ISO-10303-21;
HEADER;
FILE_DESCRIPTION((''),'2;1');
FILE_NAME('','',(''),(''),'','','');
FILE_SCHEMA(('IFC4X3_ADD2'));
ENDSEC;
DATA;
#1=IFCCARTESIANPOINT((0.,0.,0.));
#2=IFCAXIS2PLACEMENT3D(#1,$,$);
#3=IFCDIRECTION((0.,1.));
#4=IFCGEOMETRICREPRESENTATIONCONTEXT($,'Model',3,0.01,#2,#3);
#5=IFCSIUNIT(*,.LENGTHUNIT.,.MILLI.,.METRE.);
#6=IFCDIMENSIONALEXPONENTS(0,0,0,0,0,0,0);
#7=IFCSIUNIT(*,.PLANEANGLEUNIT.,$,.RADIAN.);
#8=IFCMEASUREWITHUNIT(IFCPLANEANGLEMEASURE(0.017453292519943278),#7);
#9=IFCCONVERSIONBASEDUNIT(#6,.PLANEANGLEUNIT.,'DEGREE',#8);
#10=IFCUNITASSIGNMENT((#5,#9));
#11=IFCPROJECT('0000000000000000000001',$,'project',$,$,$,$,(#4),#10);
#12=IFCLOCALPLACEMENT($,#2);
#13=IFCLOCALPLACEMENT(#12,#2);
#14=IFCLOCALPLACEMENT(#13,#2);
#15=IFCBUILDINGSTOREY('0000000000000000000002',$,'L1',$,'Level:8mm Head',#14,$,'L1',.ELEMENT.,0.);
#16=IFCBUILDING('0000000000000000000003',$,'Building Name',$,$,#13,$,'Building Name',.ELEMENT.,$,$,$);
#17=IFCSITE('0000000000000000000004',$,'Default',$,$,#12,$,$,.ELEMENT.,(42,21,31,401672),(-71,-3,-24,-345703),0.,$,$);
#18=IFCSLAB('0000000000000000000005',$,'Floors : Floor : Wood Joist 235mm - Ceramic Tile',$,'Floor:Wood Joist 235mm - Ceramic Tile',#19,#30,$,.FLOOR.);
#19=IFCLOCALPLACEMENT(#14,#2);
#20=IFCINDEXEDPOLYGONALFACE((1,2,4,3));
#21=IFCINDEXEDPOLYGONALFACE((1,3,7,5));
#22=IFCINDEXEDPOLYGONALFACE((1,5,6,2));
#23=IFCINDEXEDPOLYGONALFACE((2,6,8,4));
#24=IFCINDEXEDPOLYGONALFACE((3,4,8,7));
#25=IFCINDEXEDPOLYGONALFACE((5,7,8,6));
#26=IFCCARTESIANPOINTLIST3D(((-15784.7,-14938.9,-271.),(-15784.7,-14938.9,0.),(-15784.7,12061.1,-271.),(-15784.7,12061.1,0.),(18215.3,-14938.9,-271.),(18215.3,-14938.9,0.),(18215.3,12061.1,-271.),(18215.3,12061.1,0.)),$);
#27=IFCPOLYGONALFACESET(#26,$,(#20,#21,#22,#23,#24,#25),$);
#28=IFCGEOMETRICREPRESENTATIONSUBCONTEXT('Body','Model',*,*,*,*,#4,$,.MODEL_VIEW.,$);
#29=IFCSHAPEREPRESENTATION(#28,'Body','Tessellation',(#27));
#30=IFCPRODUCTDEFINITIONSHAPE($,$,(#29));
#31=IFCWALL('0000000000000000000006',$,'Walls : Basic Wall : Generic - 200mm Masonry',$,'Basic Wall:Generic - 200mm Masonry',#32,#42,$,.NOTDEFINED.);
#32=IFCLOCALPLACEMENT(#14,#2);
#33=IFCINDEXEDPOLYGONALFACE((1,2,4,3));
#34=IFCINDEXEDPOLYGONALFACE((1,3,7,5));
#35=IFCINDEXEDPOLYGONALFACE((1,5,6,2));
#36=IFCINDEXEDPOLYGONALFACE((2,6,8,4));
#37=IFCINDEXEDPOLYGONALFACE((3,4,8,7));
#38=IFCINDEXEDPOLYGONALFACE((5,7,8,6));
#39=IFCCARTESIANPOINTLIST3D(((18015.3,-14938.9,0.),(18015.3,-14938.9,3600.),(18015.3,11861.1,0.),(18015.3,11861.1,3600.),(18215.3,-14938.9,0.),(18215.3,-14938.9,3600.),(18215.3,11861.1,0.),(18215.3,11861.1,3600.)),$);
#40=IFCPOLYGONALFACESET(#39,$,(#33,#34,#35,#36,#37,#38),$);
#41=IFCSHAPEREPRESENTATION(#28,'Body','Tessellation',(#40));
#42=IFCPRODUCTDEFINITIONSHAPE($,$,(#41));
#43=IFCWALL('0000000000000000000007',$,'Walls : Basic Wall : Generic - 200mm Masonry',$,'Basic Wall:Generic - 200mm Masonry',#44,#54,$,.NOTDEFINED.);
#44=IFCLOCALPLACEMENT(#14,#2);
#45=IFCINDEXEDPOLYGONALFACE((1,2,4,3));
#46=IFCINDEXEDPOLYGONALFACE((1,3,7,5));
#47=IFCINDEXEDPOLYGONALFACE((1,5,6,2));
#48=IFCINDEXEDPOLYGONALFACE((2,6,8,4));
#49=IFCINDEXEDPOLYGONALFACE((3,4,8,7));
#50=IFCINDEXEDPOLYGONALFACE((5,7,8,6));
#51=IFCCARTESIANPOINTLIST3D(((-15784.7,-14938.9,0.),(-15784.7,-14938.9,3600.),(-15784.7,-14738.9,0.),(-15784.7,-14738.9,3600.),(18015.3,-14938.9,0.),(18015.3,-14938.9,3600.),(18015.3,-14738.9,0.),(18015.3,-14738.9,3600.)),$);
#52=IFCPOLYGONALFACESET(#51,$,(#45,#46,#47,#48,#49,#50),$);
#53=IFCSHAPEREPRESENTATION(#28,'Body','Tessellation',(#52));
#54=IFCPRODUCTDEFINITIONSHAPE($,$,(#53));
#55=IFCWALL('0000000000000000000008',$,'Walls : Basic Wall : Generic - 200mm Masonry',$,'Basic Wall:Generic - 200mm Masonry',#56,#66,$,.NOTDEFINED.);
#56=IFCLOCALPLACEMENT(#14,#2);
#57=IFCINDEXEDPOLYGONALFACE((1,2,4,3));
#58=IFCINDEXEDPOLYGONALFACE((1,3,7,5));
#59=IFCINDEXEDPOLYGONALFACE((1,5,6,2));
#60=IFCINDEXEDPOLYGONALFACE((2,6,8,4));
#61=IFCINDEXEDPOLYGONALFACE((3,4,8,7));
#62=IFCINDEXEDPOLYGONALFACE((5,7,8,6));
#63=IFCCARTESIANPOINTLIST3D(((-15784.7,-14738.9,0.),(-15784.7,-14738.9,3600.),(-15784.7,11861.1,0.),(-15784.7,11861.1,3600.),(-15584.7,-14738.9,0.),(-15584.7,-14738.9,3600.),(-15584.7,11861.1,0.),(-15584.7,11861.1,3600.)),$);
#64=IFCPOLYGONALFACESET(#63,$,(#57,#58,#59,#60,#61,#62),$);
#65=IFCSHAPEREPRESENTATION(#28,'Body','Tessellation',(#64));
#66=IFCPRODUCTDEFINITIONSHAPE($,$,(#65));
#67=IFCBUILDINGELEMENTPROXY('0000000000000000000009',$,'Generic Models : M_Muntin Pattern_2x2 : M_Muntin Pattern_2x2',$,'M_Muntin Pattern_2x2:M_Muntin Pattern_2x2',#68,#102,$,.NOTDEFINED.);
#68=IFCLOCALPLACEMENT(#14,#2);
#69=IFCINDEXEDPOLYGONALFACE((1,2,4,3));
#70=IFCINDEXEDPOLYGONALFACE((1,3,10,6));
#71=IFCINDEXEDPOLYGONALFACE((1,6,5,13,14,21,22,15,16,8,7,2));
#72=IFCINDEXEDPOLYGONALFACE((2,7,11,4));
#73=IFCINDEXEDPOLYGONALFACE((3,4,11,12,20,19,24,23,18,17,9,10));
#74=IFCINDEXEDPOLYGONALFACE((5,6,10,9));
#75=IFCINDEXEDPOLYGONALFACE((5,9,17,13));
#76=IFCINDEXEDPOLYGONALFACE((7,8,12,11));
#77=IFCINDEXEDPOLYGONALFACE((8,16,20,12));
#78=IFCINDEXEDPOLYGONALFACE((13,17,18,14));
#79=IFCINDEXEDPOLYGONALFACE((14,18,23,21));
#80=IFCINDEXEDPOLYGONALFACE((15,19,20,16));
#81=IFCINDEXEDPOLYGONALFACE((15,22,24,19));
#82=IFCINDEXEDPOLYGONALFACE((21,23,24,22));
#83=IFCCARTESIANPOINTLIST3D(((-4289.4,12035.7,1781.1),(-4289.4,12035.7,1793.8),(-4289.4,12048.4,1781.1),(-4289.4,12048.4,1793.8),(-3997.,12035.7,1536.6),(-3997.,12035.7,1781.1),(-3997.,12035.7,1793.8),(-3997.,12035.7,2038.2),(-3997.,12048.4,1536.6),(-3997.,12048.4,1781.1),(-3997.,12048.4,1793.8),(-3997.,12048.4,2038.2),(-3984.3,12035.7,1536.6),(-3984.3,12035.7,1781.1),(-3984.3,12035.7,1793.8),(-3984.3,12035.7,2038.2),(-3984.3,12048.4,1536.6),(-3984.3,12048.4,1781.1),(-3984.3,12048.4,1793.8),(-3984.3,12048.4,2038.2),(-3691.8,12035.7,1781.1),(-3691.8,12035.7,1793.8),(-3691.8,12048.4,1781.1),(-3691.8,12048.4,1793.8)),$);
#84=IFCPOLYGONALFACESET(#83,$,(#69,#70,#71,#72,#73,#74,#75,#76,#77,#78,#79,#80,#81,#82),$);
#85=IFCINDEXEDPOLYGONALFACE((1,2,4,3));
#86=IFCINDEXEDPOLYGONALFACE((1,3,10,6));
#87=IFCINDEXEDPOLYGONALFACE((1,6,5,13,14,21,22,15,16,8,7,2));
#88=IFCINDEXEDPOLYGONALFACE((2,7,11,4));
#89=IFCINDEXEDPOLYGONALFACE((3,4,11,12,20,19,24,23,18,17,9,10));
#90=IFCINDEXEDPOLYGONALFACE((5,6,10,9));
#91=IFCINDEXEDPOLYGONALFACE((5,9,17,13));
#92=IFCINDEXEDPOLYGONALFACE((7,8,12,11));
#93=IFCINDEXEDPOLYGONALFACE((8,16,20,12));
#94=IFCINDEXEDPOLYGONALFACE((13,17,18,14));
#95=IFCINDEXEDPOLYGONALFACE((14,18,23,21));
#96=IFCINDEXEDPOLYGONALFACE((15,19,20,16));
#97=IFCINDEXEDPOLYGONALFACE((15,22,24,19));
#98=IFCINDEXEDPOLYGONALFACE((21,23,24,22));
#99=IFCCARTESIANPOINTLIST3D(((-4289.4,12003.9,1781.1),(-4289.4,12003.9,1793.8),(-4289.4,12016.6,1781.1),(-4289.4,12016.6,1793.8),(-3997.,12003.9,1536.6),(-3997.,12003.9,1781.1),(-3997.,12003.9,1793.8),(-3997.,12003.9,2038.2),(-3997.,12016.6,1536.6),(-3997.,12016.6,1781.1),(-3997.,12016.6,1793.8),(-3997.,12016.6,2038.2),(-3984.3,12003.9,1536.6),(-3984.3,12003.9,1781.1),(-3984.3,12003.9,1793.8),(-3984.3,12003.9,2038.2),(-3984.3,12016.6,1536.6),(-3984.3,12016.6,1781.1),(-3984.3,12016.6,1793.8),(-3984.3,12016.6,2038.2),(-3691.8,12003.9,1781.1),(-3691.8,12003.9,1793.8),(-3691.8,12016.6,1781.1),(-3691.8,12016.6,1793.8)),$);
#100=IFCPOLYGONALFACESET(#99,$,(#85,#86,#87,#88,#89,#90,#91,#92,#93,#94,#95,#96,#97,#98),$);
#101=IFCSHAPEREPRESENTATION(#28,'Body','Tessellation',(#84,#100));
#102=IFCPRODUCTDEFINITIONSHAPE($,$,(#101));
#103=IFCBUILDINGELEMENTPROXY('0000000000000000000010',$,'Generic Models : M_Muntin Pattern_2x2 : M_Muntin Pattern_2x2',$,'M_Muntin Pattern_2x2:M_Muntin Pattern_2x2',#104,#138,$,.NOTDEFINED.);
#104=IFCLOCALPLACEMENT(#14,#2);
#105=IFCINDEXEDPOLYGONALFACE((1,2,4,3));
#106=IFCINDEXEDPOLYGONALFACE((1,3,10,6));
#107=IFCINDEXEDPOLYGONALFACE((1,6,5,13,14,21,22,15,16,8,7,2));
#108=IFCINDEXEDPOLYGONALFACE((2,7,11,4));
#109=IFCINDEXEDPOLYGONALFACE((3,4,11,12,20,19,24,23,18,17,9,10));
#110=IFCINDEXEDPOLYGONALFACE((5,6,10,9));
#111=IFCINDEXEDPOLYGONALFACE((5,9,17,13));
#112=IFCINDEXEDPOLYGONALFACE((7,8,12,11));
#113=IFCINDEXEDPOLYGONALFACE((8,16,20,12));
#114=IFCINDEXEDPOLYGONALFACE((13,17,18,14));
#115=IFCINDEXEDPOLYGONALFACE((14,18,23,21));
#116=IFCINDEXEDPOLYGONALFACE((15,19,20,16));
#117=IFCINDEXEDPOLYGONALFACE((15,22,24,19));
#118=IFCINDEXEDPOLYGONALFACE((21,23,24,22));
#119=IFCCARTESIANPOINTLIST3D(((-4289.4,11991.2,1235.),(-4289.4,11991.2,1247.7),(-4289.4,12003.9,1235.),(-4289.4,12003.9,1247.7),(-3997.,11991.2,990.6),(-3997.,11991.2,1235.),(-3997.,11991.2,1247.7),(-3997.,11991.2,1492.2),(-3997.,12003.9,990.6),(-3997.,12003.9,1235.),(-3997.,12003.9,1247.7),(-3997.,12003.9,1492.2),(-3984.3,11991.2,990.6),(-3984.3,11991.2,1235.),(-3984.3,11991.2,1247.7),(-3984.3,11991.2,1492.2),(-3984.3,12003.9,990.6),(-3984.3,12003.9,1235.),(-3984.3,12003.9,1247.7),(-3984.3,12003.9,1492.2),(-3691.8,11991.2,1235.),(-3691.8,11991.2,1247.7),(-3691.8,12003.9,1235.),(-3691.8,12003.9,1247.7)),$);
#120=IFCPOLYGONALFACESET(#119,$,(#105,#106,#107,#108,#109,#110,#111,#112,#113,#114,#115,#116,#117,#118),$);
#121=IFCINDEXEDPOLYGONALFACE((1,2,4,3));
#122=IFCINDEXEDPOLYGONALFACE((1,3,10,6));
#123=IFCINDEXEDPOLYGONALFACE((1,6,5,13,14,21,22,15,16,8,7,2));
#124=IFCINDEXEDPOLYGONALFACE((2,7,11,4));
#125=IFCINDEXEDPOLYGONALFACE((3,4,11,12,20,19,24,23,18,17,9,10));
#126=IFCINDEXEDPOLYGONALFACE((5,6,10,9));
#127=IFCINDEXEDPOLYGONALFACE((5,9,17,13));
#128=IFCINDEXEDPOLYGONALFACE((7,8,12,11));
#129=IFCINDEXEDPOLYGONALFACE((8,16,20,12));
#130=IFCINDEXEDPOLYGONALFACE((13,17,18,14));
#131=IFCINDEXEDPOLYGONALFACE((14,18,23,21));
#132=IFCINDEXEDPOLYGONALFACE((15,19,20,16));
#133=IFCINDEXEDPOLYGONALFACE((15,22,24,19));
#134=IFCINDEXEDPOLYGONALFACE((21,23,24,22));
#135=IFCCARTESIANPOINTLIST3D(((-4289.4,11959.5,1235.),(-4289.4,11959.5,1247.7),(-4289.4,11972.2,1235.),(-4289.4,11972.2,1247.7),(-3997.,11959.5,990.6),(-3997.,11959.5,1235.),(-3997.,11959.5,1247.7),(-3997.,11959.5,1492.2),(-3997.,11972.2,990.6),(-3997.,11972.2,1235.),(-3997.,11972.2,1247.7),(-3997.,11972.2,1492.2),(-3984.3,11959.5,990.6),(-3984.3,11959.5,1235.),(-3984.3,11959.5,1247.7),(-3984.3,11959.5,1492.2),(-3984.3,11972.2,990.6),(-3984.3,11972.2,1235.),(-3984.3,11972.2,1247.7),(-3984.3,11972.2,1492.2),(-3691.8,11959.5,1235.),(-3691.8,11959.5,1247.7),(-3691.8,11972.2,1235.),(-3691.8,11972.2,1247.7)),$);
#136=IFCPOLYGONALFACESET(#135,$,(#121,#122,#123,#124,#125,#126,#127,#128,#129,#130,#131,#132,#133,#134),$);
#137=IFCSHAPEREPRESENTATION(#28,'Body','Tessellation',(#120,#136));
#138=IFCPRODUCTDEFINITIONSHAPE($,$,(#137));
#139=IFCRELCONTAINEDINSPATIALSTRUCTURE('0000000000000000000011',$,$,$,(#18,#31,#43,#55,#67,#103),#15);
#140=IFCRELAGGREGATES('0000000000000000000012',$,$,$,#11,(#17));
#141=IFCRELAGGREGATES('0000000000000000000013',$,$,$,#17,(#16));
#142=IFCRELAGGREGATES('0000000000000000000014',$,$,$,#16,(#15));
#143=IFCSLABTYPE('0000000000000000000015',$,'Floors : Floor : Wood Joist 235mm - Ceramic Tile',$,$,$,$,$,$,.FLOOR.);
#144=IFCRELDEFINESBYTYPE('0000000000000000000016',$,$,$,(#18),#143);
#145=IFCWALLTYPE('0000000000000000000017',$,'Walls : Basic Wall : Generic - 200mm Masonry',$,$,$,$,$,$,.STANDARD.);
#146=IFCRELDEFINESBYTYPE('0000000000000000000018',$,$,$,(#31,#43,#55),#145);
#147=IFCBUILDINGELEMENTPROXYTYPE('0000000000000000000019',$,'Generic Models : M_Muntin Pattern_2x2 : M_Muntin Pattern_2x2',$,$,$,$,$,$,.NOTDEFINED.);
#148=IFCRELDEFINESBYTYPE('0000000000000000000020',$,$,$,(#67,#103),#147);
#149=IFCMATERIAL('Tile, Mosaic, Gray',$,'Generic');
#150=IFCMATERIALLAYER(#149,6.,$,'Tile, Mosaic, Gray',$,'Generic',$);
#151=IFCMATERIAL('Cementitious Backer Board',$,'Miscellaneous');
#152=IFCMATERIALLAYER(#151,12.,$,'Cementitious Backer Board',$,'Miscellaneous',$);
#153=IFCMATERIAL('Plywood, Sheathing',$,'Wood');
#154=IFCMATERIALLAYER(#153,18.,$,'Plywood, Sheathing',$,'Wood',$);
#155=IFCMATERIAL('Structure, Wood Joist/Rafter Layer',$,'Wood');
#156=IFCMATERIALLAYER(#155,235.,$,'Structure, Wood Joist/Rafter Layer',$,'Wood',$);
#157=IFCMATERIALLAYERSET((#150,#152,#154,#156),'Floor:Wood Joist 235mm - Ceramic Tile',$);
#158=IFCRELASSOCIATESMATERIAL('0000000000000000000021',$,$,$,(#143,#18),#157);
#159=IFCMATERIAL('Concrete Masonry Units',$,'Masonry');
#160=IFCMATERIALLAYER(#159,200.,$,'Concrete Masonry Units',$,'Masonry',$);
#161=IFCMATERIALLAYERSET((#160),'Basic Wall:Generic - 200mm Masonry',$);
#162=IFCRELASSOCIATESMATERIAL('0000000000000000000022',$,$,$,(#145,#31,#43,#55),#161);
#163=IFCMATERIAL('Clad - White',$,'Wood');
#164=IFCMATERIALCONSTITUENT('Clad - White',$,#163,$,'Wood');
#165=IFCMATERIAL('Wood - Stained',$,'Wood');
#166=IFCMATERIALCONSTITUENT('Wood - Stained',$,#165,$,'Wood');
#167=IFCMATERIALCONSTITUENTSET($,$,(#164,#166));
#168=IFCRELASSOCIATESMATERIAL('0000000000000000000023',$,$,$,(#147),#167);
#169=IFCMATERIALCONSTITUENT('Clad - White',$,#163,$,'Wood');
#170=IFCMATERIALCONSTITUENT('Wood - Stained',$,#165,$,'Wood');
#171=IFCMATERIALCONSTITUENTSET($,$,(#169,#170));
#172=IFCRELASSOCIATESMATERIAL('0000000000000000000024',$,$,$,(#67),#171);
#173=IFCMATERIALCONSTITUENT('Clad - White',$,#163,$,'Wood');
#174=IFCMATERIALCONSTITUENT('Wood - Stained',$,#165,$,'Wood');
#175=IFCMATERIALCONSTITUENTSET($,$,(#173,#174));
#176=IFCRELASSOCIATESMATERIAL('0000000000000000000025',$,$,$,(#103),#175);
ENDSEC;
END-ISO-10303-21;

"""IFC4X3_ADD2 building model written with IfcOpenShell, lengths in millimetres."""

from ifc_helpers import new_model, entity, si_unit, converted_unit, direction, frame, frame_2d, origin, origin_2d_with_axis, place, context, subcontext, project, spatial, polyline, rectangle, outline, extrude, source, transform, mapped, material, layer, layer_set, layer_usage, constituent, constituent_set, type_object, type_shapes, element, save


model = new_model("IFC4X3_ADD2")

# Units and contexts
model_context = context("Model", 3, precision=0.01, world=origin(), true_north=direction((0.0, 1.0)))
body_context = subcontext(model_context, "Body", "Model", "MODEL_VIEW")
ifc_project = project(units=[si_unit("LENGTHUNIT", "METRE", prefix="MILLI"), converted_unit("PLANEANGLEUNIT", "DEGREE", entity("IfcPlaneAngleMeasure", 0.017453292519943278), si_unit("PLANEANGLEUNIT", "RADIAN"), dimensions=[0, 0, 0, 0, 0, 0, 0])], contexts=[model_context])

# Site, building, storey
site_placement = place(None, origin())
site = spatial("IfcSite", under=ifc_project, at=site_placement, Name="Default", CompositionType="ELEMENT", RefLatitude=(42, 21, 31, 401672), RefLongitude=(-71, -3, -24, -345703), RefElevation=0.0)
building_placement = place(site_placement, origin())
building = spatial("IfcBuilding", under=site, at=building_placement, Name="Building Name", LongName="Building Name", CompositionType="ELEMENT")
storey_placement = place(building_placement, origin())
storey = spatial("IfcBuildingStorey", under=building, at=storey_placement, Name="L1", ObjectType="Level:8mm Head", LongName="L1", CompositionType="ELEMENT", Elevation=0.0)

# Slab
ifc_material_1 = material(Name="Tile, Mosaic, Gray", Category="Generic")
ifc_layer_1 = layer(ifc_material_1, 6.0, Name="Tile, Mosaic, Gray", Category="Generic")
ifc_material_2 = material(Name="Cementitious Backer Board", Category="Miscellaneous")
ifc_layer_2 = layer(ifc_material_2, 12.0, Name="Cementitious Backer Board", Category="Miscellaneous")
ifc_material_3 = material(Name="Plywood, Sheathing", Category="Wood")
ifc_layer_3 = layer(ifc_material_3, 18.0, Name="Plywood, Sheathing", Category="Wood")
ifc_material_4 = material(Name="Structure, Wood Joist/Rafter Layer", Category="Wood")
ifc_layer_4 = layer(ifc_material_4, 235.0, Name="Structure, Wood Joist/Rafter Layer", Category="Wood")
ifc_layer_set_1 = layer_set([ifc_layer_1, ifc_layer_2, ifc_layer_3, ifc_layer_4], Name="Floor:Wood Joist 235mm - Ceramic Tile")
ifc_layer_usage = layer_usage(ifc_layer_set_1, "AXIS3", "POSITIVE", 0.0)
slab_type = type_object("IfcSlabType", Name="Floors : Floor : Wood Joist 235mm - Ceramic Tile", PredefinedType="FLOOR", material=ifc_layer_set_1)
slab_placement = place(storey_placement, origin())
element("IfcSlab", 1, at=slab_placement, inside=storey, type_object=slab_type, material=ifc_layer_usage, Name="Floors : Floor : Wood Joist 235mm - Ceramic Tile", ObjectType="Floor:Wood Joist 235mm - Ceramic Tile", PredefinedType="FLOOR", context=body_context, shape_type="SweptSolid", body=[
    extrude(rectangle(XDim=27000.0, YDim=34000.0, at=origin_2d_with_axis()), frame((1215.3, -1438.9, 0.0), z_axis=(0.0, 0.0, -1.0), x_axis=(0.0, 1.0, 0.0)), (0.0, 0.0, 1.0), 271.0),
])

# Shared definitions
ifc_material_5 = material(Name="Concrete Masonry Units", Category="Masonry")
ifc_layer_5 = layer(ifc_material_5, 200.0, Name="Concrete Masonry Units", Category="Masonry")
ifc_layer_set_2 = layer_set([ifc_layer_5], Name="Basic Wall:Generic - 200mm Masonry")
wall_type = type_object("IfcWallType", Name="Walls : Basic Wall : Generic - 200mm Masonry", PredefinedType="STANDARD", material=ifc_layer_set_2)
ifc_material_6 = material(Name="Wood - Stained", Category="Wood")

# Walls
wall_1_placement = place(storey_placement, frame((18115.3, 11861.1, 0.0), z_axis=(0.0, 0.0, 1.0), x_axis=(0.0, -1.0, 0.0)))
element("IfcWall", 2, at=wall_1_placement, inside=storey, type_object=wall_type, material=ifc_layer_set_2, Name="Walls : Basic Wall : Generic - 200mm Masonry", ObjectType="Basic Wall:Generic - 200mm Masonry", PredefinedType="NOTDEFINED", context=body_context, shape_type="SweptSolid", body=[
    extrude(rectangle(XDim=26800.0, YDim=200.0, at=frame_2d((13400.0, 0.0), x_axis=(-1.0, 0.0))), origin(), (0.0, 0.0, 1.0), 3600.0),
])
wall_2_placement = place(storey_placement, frame((18015.3, -14838.9, 0.0), z_axis=(0.0, 0.0, 1.0), x_axis=(-1.0, 0.0, 0.0)))
element("IfcWall", 3, at=wall_2_placement, inside=storey, type_object=wall_type, material=ifc_layer_set_2, Name="Walls : Basic Wall : Generic - 200mm Masonry", ObjectType="Basic Wall:Generic - 200mm Masonry", PredefinedType="NOTDEFINED", context=body_context, shape_type="SweptSolid", body=[
    extrude(rectangle(XDim=33800.0, YDim=200.0, at=frame_2d((16900.0, 0.0), x_axis=(-1.0, 0.0))), origin(), (0.0, 0.0, 1.0), 3600.0),
])
wall_3_placement = place(storey_placement, frame((-15684.7, -14738.9, 0.0), z_axis=(0.0, 0.0, 1.0), x_axis=(0.0, 1.0, 0.0)))
element("IfcWall", 4, at=wall_3_placement, inside=storey, type_object=wall_type, material=ifc_layer_set_2, Name="Walls : Basic Wall : Generic - 200mm Masonry", ObjectType="Basic Wall:Generic - 200mm Masonry", PredefinedType="NOTDEFINED", context=body_context, shape_type="SweptSolid", body=[
    extrude(rectangle(XDim=26600.0, YDim=200.0, at=frame_2d((13300.0, 0.0), x_axis=(-1.0, 0.0))), origin(), (0.0, 0.0, 1.0), 3600.0),
])

# Building element proxies
ifc_material_7 = material(Name="Clad - White", Category="Wood")
ifc_constituent_1 = constituent(ifc_material_7, Name="Clad - White", Category="Wood")
ifc_constituent_2 = constituent(ifc_material_6, Name="Wood - Stained", Category="Wood")
ifc_constituent_set_1 = constituent_set(constituents=[ifc_constituent_1, ifc_constituent_2])
ifc_constituent_3 = constituent(ifc_material_7, Name="Clad - White", Category="Wood")
ifc_constituent_4 = constituent(ifc_material_6, Name="Wood - Stained", Category="Wood")
ifc_constituent_set_2 = constituent_set(constituents=[ifc_constituent_3, ifc_constituent_4])
building_element_proxy_type_1 = type_object("IfcBuildingElementProxyType", Name="Generic Models : M_Muntin Pattern_2x2 : M_Muntin Pattern_2x2", PredefinedType="NOTDEFINED", material=ifc_constituent_set_2)
shared_shape_1 = source(origin(), body_context, "Body", "SweptSolid", [
    extrude(outline(polyline([(6.4, -6.4), (250.8, -6.4), (250.8, 6.3), (6.4, 6.3), (6.4, 298.8), (-6.3, 298.8), (-6.3, 6.3), (-250.8, 6.3), (-250.8, -6.4), (-6.3, -6.4), (-6.3, -298.8), (6.4, -298.8), (6.4, -6.4)])), frame((0.0, 9.5, 250.8), z_axis=(0.0, 1.0, 0.0), x_axis=(0.0, 0.0, 1.0)), (0.0, 0.0, 1.0), 12.7),
    extrude(outline(polyline([(6.4, -6.4), (250.8, -6.4), (250.8, 6.3), (6.4, 6.3), (6.4, 298.8), (-6.3, 298.8), (-6.3, 6.3), (-250.8, 6.3), (-250.8, -6.4), (-6.3, -6.4), (-6.3, -298.8), (6.4, -298.8), (6.4, -6.4)])), frame((0.0, -22.2, 250.8), z_axis=(0.0, 1.0, 0.0), x_axis=(0.0, 0.0, 1.0)), (0.0, 0.0, 1.0), 12.7),
])
type_shapes(building_element_proxy_type_1, [shared_shape_1])
proxy_1_placement = place(storey_placement, frame((-3990.6, 12026.1, 1536.6)))
element("IfcBuildingElementProxy", 5, at=proxy_1_placement, inside=storey, type_object=building_element_proxy_type_1, material=ifc_constituent_set_1, Name="Generic Models : M_Muntin Pattern_2x2 : M_Muntin Pattern_2x2", ObjectType="M_Muntin Pattern_2x2:M_Muntin Pattern_2x2", PredefinedType="NOTDEFINED", context=body_context, shape_type="MappedRepresentation", body=[
    mapped(shared_shape_1, transform((0.0, 0.0, 0.0), scale=1.0)),
])
ifc_constituent_5 = constituent(ifc_material_7, Name="Clad - White", Category="Wood")
ifc_constituent_6 = constituent(ifc_material_6, Name="Wood - Stained", Category="Wood")
ifc_constituent_set_3 = constituent_set(constituents=[ifc_constituent_5, ifc_constituent_6])
proxy_2_placement = place(storey_placement, frame((-3990.6, 11981.7, 990.6)))
element("IfcBuildingElementProxy", 6, at=proxy_2_placement, inside=storey, type_object=building_element_proxy_type_1, material=ifc_constituent_set_3, Name="Generic Models : M_Muntin Pattern_2x2 : M_Muntin Pattern_2x2", ObjectType="M_Muntin Pattern_2x2:M_Muntin Pattern_2x2", PredefinedType="NOTDEFINED", context=body_context, shape_type="MappedRepresentation", body=[
    mapped(shared_shape_1, transform((0.0, 0.0, 0.0), scale=1.0)),
])

save(model, "model.ifc")
